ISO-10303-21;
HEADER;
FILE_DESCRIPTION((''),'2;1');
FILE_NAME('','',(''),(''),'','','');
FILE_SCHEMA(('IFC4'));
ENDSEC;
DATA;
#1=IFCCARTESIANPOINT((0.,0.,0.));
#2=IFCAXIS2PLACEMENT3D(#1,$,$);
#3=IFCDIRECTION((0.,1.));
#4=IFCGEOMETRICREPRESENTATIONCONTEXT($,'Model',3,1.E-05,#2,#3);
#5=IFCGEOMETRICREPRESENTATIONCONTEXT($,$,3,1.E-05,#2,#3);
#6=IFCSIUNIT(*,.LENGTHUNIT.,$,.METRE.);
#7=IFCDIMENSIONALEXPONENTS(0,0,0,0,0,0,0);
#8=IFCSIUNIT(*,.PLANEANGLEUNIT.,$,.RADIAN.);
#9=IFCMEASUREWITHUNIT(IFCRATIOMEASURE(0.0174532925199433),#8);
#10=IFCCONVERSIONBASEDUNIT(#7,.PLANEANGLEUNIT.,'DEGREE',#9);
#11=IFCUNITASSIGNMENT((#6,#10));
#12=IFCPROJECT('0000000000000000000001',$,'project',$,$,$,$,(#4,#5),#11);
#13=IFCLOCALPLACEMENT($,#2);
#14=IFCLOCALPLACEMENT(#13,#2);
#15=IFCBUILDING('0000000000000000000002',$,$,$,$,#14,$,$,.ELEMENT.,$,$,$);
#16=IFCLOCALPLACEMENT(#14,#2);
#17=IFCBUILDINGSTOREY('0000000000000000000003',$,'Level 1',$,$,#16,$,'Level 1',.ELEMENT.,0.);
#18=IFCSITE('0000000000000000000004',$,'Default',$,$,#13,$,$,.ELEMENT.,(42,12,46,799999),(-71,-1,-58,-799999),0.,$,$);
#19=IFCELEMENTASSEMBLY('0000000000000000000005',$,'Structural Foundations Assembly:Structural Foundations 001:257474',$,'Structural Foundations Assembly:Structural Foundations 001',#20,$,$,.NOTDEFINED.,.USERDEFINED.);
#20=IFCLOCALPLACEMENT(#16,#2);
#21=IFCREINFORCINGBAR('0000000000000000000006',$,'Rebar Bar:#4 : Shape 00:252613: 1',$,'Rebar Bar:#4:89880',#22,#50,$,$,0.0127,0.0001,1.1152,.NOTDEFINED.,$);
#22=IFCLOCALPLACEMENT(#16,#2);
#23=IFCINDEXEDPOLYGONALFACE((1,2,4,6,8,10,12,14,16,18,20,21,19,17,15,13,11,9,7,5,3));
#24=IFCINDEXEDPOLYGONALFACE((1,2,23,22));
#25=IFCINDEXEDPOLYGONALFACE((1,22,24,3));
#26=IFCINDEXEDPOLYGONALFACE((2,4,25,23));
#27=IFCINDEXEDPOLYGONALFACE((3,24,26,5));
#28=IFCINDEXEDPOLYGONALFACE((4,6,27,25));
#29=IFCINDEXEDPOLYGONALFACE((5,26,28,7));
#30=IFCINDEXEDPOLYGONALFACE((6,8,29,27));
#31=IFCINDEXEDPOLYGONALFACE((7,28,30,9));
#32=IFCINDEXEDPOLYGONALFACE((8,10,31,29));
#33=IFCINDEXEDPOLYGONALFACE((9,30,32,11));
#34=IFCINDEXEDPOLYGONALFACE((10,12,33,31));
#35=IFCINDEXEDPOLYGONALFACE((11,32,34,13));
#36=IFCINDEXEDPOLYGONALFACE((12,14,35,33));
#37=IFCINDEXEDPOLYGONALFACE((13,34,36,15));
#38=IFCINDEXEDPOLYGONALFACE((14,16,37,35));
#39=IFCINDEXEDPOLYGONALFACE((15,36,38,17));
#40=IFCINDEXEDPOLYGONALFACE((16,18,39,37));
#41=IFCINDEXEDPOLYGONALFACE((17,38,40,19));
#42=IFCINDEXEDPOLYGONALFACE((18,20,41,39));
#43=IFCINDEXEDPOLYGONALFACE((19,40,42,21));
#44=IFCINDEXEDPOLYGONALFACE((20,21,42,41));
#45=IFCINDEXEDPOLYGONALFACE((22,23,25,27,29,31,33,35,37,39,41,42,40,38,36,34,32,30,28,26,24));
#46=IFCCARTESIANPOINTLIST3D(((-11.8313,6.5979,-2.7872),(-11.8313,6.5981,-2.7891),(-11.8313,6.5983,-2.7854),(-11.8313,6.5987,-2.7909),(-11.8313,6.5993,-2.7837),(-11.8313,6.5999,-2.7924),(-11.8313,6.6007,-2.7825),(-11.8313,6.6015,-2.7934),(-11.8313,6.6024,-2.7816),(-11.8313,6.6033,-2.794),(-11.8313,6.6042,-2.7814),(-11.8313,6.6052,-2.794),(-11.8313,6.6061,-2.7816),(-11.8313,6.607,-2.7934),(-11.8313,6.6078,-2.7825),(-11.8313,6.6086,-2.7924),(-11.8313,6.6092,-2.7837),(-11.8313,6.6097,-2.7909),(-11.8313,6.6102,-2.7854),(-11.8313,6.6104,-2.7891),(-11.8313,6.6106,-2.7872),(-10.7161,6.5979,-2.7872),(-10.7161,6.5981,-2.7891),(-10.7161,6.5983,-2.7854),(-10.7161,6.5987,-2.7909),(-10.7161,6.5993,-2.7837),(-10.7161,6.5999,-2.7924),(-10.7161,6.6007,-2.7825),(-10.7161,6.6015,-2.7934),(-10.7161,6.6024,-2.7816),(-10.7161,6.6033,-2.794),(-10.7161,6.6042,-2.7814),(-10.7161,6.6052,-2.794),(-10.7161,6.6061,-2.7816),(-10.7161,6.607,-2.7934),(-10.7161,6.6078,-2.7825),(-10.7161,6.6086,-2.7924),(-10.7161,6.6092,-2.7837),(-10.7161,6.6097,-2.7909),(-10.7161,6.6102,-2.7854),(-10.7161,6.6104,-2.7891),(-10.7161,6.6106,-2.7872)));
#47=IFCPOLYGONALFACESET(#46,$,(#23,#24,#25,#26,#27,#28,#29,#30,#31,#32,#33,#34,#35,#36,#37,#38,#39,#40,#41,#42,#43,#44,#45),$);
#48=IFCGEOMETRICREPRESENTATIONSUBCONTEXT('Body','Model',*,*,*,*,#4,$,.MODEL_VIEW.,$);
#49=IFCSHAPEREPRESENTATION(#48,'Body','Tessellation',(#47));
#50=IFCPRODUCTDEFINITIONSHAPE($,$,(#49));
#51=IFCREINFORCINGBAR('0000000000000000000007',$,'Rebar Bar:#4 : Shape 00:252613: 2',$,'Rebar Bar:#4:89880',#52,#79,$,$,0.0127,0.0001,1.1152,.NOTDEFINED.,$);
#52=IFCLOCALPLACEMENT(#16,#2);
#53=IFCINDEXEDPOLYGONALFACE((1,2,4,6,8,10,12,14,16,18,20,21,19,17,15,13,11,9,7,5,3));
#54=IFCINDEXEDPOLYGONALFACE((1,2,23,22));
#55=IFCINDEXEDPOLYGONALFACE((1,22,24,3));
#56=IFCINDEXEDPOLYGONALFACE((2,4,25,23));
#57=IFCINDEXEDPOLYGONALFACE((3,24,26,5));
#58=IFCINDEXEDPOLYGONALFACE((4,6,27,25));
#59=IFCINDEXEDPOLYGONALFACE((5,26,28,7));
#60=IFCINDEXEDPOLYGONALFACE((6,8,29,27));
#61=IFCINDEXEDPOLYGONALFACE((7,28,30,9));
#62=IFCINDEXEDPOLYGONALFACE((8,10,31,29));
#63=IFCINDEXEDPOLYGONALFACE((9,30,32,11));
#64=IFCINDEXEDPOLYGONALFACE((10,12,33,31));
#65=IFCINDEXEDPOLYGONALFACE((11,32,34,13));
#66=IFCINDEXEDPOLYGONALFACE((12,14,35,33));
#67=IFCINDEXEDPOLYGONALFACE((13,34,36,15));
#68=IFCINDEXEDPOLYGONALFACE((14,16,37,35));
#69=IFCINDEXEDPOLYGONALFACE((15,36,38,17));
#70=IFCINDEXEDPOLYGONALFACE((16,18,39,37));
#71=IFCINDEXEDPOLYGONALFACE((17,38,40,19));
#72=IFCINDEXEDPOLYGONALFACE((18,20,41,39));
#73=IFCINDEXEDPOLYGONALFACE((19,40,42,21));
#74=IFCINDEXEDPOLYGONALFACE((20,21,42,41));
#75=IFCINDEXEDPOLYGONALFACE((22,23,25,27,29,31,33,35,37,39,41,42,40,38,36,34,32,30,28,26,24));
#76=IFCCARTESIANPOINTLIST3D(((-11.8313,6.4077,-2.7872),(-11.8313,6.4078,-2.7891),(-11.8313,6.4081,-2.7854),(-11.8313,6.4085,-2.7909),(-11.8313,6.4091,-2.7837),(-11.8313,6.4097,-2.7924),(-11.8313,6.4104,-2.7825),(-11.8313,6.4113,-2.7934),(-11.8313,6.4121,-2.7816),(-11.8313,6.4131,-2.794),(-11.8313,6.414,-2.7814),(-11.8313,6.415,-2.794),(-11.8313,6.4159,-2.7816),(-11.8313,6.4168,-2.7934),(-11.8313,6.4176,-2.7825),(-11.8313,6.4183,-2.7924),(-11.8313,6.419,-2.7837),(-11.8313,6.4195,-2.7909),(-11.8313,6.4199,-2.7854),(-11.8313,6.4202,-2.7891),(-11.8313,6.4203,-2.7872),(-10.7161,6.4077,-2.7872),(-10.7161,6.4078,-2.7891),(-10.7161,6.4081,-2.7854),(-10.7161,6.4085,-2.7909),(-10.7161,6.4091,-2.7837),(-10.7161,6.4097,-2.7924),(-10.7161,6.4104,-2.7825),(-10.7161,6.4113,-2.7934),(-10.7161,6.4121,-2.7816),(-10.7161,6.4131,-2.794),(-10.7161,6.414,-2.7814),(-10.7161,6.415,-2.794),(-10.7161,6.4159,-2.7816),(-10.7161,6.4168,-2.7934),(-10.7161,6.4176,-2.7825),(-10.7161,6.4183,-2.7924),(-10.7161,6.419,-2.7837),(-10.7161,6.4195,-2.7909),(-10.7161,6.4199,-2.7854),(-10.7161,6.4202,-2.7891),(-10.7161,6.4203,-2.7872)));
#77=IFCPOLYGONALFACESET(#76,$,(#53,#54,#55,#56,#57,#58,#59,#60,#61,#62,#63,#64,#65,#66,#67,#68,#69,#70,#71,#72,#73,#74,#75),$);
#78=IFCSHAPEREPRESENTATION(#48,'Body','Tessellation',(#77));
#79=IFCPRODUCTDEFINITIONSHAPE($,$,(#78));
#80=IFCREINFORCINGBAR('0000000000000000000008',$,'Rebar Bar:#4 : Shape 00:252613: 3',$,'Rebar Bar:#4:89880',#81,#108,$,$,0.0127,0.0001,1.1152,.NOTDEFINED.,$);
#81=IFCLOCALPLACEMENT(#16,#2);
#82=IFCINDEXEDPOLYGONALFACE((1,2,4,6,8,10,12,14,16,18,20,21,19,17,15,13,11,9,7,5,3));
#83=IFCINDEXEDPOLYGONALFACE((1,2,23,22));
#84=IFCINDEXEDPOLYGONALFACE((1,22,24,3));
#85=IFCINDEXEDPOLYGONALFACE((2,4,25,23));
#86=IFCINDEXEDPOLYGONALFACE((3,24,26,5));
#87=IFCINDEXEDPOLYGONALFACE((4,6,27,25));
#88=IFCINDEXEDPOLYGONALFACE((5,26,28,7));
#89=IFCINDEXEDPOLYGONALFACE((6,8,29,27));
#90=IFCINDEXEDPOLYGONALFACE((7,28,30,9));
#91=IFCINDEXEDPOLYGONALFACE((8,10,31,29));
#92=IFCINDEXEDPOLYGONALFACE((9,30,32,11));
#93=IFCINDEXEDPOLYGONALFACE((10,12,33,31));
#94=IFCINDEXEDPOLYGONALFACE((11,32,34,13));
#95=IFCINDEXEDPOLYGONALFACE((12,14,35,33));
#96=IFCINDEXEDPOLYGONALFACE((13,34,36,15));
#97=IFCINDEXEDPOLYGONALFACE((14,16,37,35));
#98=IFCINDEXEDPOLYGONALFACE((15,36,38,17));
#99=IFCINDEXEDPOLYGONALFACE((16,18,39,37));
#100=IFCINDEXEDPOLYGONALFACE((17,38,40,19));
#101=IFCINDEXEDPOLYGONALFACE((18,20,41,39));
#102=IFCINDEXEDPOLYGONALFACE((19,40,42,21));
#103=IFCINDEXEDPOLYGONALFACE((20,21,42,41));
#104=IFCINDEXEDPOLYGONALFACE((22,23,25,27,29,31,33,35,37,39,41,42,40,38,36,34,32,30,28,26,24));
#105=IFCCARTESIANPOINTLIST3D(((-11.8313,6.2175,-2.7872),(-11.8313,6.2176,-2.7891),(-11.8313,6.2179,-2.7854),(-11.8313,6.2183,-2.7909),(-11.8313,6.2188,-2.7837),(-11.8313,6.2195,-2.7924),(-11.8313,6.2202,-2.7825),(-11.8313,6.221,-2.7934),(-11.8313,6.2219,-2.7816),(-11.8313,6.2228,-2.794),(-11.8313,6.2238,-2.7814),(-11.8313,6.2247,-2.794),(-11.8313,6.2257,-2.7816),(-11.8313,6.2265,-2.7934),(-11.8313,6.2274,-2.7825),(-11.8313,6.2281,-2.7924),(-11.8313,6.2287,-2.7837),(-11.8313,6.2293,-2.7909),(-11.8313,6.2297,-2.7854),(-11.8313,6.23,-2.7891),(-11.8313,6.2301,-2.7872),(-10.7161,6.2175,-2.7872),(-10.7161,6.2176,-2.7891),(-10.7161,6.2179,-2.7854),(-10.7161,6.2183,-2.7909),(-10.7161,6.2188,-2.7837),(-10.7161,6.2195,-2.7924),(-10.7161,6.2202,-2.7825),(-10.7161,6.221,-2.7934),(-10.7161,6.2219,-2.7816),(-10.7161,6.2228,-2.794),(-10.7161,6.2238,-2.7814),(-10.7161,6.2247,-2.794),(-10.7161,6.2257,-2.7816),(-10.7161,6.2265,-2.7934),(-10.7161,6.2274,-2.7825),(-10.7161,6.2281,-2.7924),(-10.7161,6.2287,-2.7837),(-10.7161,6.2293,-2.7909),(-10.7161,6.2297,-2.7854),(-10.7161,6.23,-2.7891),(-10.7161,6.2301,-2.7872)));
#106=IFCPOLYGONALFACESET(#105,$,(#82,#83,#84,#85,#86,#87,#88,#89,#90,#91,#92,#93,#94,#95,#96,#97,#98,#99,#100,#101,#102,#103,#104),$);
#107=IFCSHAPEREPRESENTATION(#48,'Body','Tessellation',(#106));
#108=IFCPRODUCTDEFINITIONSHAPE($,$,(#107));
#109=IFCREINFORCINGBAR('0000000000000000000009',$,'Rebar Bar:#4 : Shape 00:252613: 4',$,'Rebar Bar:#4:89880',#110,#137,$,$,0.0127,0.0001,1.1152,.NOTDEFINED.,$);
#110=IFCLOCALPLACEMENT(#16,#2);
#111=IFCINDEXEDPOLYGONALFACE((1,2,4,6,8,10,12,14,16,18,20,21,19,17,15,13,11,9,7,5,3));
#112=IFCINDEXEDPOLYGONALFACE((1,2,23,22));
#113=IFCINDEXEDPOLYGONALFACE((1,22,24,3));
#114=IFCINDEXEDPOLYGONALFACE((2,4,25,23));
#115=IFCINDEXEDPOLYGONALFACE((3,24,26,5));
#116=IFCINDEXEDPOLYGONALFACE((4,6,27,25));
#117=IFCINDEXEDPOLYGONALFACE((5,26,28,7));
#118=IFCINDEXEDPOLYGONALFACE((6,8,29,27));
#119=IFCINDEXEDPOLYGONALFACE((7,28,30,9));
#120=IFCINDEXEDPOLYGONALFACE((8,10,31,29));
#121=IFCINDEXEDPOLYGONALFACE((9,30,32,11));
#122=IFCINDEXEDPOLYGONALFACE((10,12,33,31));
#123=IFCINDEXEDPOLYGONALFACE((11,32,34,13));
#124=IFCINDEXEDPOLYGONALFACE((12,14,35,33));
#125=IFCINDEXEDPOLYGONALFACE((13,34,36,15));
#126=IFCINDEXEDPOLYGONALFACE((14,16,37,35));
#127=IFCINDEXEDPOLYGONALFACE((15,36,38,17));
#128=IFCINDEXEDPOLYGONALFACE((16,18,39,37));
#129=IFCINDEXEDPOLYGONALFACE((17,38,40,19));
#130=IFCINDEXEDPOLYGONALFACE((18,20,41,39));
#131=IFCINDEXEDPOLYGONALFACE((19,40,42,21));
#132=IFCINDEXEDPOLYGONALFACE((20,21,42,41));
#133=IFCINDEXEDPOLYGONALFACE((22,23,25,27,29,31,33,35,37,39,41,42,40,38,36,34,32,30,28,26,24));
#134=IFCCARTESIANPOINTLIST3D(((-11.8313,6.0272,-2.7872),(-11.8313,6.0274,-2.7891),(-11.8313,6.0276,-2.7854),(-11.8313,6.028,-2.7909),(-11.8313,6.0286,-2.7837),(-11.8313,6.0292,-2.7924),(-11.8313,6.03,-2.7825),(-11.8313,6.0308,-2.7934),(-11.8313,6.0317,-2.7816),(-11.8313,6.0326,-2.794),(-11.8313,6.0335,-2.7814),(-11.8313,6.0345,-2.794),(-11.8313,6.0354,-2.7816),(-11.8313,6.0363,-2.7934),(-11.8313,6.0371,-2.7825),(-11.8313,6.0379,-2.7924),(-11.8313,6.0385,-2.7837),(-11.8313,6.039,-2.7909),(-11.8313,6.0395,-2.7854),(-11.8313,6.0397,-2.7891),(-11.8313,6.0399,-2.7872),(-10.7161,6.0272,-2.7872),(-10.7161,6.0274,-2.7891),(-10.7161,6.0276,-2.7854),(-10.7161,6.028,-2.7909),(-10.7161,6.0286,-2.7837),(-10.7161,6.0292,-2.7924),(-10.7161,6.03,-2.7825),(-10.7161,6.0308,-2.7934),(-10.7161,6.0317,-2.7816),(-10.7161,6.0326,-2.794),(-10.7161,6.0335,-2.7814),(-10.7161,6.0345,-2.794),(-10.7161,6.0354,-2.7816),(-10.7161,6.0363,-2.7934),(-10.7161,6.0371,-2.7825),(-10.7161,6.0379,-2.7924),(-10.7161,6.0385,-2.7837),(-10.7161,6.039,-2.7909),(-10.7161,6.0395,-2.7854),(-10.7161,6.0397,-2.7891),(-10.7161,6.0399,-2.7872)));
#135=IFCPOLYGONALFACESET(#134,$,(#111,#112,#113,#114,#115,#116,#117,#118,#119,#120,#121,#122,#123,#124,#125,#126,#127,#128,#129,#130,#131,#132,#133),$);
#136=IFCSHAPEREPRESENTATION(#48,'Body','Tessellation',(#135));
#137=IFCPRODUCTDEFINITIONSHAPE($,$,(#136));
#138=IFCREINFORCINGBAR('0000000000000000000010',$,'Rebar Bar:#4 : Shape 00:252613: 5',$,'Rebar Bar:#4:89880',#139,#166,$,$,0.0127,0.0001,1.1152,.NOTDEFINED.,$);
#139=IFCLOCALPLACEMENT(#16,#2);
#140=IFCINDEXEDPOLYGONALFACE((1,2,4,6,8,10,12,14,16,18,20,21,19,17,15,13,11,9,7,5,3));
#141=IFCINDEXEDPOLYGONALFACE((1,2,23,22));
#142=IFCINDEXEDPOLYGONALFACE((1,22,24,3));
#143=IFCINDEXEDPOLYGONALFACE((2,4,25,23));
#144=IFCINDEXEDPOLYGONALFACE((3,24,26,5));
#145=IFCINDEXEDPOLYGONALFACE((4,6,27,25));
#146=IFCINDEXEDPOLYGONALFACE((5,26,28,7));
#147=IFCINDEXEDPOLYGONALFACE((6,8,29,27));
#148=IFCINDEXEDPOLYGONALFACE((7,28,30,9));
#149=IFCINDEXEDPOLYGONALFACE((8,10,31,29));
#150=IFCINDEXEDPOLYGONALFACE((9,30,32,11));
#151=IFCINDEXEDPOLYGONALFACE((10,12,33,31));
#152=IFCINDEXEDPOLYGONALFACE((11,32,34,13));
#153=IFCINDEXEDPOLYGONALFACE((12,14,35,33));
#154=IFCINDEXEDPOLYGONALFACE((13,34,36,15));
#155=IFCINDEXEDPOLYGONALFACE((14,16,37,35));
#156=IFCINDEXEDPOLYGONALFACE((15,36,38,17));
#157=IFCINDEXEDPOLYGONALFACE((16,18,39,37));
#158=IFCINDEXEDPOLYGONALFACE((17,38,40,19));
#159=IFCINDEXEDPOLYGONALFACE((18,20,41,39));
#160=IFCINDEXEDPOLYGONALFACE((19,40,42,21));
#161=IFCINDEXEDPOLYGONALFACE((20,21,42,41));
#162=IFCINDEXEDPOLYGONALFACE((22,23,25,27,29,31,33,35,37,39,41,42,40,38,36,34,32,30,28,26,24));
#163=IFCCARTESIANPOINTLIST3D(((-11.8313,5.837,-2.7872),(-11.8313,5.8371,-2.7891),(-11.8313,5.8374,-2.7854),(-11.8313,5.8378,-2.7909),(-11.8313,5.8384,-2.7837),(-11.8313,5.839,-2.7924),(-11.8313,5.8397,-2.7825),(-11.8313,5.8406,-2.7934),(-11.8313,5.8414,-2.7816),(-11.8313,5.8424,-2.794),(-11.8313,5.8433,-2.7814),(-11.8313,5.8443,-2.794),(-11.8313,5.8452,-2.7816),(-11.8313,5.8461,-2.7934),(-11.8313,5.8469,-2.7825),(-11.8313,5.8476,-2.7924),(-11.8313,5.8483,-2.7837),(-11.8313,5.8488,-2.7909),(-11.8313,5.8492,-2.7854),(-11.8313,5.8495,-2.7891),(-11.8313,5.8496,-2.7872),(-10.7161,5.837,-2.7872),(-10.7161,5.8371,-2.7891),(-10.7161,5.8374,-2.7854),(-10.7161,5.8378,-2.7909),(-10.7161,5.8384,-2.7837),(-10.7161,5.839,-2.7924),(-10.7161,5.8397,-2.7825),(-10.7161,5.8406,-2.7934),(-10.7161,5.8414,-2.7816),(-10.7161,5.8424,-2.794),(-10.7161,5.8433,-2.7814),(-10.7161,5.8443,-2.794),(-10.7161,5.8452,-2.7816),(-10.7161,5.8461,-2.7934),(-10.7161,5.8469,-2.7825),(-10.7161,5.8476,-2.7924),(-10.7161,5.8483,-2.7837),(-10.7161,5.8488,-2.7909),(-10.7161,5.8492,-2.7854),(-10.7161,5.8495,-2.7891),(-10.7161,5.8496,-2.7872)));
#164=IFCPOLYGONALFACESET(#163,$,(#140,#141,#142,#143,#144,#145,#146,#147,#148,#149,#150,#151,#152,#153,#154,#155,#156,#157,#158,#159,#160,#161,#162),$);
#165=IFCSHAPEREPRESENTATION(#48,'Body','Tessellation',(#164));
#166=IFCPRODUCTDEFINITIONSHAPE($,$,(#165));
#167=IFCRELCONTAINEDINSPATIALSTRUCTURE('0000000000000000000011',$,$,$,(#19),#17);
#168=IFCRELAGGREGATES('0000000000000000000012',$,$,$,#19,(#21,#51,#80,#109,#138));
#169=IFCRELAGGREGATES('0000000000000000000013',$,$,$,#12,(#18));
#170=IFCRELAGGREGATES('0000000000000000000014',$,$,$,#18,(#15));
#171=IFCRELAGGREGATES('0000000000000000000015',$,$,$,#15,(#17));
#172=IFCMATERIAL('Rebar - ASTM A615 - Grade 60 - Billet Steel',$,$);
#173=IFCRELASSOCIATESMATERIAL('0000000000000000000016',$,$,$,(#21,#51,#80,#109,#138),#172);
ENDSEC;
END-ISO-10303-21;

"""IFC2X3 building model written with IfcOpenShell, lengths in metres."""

from ifc_helpers import new_model, entity, si_unit, converted_unit, direction, origin, place, context, subcontext, project, spatial, material, element, aggregate, save


model = new_model("IFC2X3")

# Units and contexts
model_context = context("Model", 3, precision=1e-05, world=origin(), true_north=direction((0.0, 1.0)))
context_of_model = context(None, 3, precision=1e-05, world=origin(), true_north=direction((0.0, 1.0)))
body_context = subcontext(model_context, "Body", "Model", "MODEL_VIEW")
ifc_project = project(units=[si_unit("LENGTHUNIT", "METRE"), converted_unit("PLANEANGLEUNIT", "DEGREE", entity("IfcRatioMeasure", 0.0174532925199433), si_unit("PLANEANGLEUNIT", "RADIAN"), dimensions=[0, 0, 0, 0, 0, 0, 0])], contexts=[model_context, context_of_model])

# Site, building, storey
site_placement = place(None, origin())
site = spatial("IfcSite", under=ifc_project, at=site_placement, Name="Default", CompositionType="ELEMENT", RefLatitude=(42, 12, 46, 799999), RefLongitude=(-71, -1, -58, -799999), RefElevation=0.0)
building_placement = place(site_placement, origin())
building = spatial("IfcBuilding", under=site, at=building_placement, CompositionType="ELEMENT")
storey_placement = place(building_placement, origin())
storey = spatial("IfcBuildingStorey", under=building, at=storey_placement, Name="Level 1", LongName="Level 1", CompositionType="ELEMENT", Elevation=0.0)

# Element assembly
assembly_1_placement = place(storey_placement, origin())
assembly_1 = element("IfcElementAssembly", 1, at=assembly_1_placement, inside=storey, Name="Structural Foundations Assembly:Structural Foundations 001:257474", ObjectType="Structural Foundations Assembly:Structural Foundations 001", AssemblyPlace="NOTDEFINED", PredefinedType="USERDEFINED")

# Shared definitions
ifc_material_1 = material(Name="Rebar - ASTM A615 - Grade 60 - Billet Steel")

# Reinforcing bars
reinforcing_bar_1_placement = place(assembly_1_placement, origin())
reinforcing_bar_1 = element("IfcReinforcingBar", 2, at=reinforcing_bar_1_placement, material=ifc_material_1, Name="Rebar Bar:#4 : Shape 00:252613: 1", ObjectType="Rebar Bar:#4:89880", BarLength=1.1152, BarRole="NOTDEFINED", CrossSectionArea=0.0001, NominalDiameter=0.0127, context=body_context, shape_type="AdvancedSweptSolid", body=[
    entity("IfcSweptDiskSolid", entity("IfcCompositeCurve", [entity("IfcCompositeCurveSegment", "CONTINUOUS", True, entity("IfcPolyline", [entity("IfcCartesianPoint", [-11.8313, 6.6042, -2.7877]), entity("IfcCartesianPoint", [-10.7161, 6.6042, -2.7877])]))], False), 0.0063, None, 0.0, 1.0),
])
reinforcing_bar_2_placement = place(assembly_1_placement, origin())
reinforcing_bar_2 = element("IfcReinforcingBar", 3, at=reinforcing_bar_2_placement, material=ifc_material_1, Name="Rebar Bar:#4 : Shape 00:252613: 2", ObjectType="Rebar Bar:#4:89880", BarLength=1.1152, BarRole="NOTDEFINED", CrossSectionArea=0.0001, NominalDiameter=0.0127, context=body_context, shape_type="AdvancedSweptSolid", body=[
    entity("IfcSweptDiskSolid", entity("IfcCompositeCurve", [entity("IfcCompositeCurveSegment", "CONTINUOUS", True, entity("IfcPolyline", [entity("IfcCartesianPoint", [-11.8313, 6.414, -2.7877]), entity("IfcCartesianPoint", [-10.7161, 6.414, -2.7877])]))], False), 0.0063, None, 0.0, 1.0),
])
reinforcing_bar_3_placement = place(assembly_1_placement, origin())
reinforcing_bar_3 = element("IfcReinforcingBar", 4, at=reinforcing_bar_3_placement, material=ifc_material_1, Name="Rebar Bar:#4 : Shape 00:252613: 3", ObjectType="Rebar Bar:#4:89880", BarLength=1.1152, BarRole="NOTDEFINED", CrossSectionArea=0.0001, NominalDiameter=0.0127, context=body_context, shape_type="AdvancedSweptSolid", body=[
    entity("IfcSweptDiskSolid", entity("IfcCompositeCurve", [entity("IfcCompositeCurveSegment", "CONTINUOUS", True, entity("IfcPolyline", [entity("IfcCartesianPoint", [-11.8313, 6.2238, -2.7877]), entity("IfcCartesianPoint", [-10.7161, 6.2238, -2.7877])]))], False), 0.0063, None, 0.0, 1.0),
])
reinforcing_bar_4_placement = place(assembly_1_placement, origin())
reinforcing_bar_4 = element("IfcReinforcingBar", 5, at=reinforcing_bar_4_placement, material=ifc_material_1, Name="Rebar Bar:#4 : Shape 00:252613: 4", ObjectType="Rebar Bar:#4:89880", BarLength=1.1152, BarRole="NOTDEFINED", CrossSectionArea=0.0001, NominalDiameter=0.0127, context=body_context, shape_type="AdvancedSweptSolid", body=[
    entity("IfcSweptDiskSolid", entity("IfcCompositeCurve", [entity("IfcCompositeCurveSegment", "CONTINUOUS", True, entity("IfcPolyline", [entity("IfcCartesianPoint", [-11.8313, 6.0335, -2.7877]), entity("IfcCartesianPoint", [-10.7161, 6.0335, -2.7877])]))], False), 0.0063, None, 0.0, 1.0),
])
reinforcing_bar_5_placement = place(assembly_1_placement, origin())
reinforcing_bar_5 = element("IfcReinforcingBar", 6, at=reinforcing_bar_5_placement, material=ifc_material_1, Name="Rebar Bar:#4 : Shape 00:252613: 5", ObjectType="Rebar Bar:#4:89880", BarLength=1.1152, BarRole="NOTDEFINED", CrossSectionArea=0.0001, NominalDiameter=0.0127, context=body_context, shape_type="AdvancedSweptSolid", body=[
    entity("IfcSweptDiskSolid", entity("IfcCompositeCurve", [entity("IfcCompositeCurveSegment", "CONTINUOUS", True, entity("IfcPolyline", [entity("IfcCartesianPoint", [-11.8313, 5.8433, -2.7877]), entity("IfcCartesianPoint", [-10.7161, 5.8433, -2.7877])]))], False), 0.0063, None, 0.0, 1.0),
])
aggregate(assembly_1, [reinforcing_bar_1, reinforcing_bar_2, reinforcing_bar_3, reinforcing_bar_4, reinforcing_bar_5])

save(model, "model.ifc")
